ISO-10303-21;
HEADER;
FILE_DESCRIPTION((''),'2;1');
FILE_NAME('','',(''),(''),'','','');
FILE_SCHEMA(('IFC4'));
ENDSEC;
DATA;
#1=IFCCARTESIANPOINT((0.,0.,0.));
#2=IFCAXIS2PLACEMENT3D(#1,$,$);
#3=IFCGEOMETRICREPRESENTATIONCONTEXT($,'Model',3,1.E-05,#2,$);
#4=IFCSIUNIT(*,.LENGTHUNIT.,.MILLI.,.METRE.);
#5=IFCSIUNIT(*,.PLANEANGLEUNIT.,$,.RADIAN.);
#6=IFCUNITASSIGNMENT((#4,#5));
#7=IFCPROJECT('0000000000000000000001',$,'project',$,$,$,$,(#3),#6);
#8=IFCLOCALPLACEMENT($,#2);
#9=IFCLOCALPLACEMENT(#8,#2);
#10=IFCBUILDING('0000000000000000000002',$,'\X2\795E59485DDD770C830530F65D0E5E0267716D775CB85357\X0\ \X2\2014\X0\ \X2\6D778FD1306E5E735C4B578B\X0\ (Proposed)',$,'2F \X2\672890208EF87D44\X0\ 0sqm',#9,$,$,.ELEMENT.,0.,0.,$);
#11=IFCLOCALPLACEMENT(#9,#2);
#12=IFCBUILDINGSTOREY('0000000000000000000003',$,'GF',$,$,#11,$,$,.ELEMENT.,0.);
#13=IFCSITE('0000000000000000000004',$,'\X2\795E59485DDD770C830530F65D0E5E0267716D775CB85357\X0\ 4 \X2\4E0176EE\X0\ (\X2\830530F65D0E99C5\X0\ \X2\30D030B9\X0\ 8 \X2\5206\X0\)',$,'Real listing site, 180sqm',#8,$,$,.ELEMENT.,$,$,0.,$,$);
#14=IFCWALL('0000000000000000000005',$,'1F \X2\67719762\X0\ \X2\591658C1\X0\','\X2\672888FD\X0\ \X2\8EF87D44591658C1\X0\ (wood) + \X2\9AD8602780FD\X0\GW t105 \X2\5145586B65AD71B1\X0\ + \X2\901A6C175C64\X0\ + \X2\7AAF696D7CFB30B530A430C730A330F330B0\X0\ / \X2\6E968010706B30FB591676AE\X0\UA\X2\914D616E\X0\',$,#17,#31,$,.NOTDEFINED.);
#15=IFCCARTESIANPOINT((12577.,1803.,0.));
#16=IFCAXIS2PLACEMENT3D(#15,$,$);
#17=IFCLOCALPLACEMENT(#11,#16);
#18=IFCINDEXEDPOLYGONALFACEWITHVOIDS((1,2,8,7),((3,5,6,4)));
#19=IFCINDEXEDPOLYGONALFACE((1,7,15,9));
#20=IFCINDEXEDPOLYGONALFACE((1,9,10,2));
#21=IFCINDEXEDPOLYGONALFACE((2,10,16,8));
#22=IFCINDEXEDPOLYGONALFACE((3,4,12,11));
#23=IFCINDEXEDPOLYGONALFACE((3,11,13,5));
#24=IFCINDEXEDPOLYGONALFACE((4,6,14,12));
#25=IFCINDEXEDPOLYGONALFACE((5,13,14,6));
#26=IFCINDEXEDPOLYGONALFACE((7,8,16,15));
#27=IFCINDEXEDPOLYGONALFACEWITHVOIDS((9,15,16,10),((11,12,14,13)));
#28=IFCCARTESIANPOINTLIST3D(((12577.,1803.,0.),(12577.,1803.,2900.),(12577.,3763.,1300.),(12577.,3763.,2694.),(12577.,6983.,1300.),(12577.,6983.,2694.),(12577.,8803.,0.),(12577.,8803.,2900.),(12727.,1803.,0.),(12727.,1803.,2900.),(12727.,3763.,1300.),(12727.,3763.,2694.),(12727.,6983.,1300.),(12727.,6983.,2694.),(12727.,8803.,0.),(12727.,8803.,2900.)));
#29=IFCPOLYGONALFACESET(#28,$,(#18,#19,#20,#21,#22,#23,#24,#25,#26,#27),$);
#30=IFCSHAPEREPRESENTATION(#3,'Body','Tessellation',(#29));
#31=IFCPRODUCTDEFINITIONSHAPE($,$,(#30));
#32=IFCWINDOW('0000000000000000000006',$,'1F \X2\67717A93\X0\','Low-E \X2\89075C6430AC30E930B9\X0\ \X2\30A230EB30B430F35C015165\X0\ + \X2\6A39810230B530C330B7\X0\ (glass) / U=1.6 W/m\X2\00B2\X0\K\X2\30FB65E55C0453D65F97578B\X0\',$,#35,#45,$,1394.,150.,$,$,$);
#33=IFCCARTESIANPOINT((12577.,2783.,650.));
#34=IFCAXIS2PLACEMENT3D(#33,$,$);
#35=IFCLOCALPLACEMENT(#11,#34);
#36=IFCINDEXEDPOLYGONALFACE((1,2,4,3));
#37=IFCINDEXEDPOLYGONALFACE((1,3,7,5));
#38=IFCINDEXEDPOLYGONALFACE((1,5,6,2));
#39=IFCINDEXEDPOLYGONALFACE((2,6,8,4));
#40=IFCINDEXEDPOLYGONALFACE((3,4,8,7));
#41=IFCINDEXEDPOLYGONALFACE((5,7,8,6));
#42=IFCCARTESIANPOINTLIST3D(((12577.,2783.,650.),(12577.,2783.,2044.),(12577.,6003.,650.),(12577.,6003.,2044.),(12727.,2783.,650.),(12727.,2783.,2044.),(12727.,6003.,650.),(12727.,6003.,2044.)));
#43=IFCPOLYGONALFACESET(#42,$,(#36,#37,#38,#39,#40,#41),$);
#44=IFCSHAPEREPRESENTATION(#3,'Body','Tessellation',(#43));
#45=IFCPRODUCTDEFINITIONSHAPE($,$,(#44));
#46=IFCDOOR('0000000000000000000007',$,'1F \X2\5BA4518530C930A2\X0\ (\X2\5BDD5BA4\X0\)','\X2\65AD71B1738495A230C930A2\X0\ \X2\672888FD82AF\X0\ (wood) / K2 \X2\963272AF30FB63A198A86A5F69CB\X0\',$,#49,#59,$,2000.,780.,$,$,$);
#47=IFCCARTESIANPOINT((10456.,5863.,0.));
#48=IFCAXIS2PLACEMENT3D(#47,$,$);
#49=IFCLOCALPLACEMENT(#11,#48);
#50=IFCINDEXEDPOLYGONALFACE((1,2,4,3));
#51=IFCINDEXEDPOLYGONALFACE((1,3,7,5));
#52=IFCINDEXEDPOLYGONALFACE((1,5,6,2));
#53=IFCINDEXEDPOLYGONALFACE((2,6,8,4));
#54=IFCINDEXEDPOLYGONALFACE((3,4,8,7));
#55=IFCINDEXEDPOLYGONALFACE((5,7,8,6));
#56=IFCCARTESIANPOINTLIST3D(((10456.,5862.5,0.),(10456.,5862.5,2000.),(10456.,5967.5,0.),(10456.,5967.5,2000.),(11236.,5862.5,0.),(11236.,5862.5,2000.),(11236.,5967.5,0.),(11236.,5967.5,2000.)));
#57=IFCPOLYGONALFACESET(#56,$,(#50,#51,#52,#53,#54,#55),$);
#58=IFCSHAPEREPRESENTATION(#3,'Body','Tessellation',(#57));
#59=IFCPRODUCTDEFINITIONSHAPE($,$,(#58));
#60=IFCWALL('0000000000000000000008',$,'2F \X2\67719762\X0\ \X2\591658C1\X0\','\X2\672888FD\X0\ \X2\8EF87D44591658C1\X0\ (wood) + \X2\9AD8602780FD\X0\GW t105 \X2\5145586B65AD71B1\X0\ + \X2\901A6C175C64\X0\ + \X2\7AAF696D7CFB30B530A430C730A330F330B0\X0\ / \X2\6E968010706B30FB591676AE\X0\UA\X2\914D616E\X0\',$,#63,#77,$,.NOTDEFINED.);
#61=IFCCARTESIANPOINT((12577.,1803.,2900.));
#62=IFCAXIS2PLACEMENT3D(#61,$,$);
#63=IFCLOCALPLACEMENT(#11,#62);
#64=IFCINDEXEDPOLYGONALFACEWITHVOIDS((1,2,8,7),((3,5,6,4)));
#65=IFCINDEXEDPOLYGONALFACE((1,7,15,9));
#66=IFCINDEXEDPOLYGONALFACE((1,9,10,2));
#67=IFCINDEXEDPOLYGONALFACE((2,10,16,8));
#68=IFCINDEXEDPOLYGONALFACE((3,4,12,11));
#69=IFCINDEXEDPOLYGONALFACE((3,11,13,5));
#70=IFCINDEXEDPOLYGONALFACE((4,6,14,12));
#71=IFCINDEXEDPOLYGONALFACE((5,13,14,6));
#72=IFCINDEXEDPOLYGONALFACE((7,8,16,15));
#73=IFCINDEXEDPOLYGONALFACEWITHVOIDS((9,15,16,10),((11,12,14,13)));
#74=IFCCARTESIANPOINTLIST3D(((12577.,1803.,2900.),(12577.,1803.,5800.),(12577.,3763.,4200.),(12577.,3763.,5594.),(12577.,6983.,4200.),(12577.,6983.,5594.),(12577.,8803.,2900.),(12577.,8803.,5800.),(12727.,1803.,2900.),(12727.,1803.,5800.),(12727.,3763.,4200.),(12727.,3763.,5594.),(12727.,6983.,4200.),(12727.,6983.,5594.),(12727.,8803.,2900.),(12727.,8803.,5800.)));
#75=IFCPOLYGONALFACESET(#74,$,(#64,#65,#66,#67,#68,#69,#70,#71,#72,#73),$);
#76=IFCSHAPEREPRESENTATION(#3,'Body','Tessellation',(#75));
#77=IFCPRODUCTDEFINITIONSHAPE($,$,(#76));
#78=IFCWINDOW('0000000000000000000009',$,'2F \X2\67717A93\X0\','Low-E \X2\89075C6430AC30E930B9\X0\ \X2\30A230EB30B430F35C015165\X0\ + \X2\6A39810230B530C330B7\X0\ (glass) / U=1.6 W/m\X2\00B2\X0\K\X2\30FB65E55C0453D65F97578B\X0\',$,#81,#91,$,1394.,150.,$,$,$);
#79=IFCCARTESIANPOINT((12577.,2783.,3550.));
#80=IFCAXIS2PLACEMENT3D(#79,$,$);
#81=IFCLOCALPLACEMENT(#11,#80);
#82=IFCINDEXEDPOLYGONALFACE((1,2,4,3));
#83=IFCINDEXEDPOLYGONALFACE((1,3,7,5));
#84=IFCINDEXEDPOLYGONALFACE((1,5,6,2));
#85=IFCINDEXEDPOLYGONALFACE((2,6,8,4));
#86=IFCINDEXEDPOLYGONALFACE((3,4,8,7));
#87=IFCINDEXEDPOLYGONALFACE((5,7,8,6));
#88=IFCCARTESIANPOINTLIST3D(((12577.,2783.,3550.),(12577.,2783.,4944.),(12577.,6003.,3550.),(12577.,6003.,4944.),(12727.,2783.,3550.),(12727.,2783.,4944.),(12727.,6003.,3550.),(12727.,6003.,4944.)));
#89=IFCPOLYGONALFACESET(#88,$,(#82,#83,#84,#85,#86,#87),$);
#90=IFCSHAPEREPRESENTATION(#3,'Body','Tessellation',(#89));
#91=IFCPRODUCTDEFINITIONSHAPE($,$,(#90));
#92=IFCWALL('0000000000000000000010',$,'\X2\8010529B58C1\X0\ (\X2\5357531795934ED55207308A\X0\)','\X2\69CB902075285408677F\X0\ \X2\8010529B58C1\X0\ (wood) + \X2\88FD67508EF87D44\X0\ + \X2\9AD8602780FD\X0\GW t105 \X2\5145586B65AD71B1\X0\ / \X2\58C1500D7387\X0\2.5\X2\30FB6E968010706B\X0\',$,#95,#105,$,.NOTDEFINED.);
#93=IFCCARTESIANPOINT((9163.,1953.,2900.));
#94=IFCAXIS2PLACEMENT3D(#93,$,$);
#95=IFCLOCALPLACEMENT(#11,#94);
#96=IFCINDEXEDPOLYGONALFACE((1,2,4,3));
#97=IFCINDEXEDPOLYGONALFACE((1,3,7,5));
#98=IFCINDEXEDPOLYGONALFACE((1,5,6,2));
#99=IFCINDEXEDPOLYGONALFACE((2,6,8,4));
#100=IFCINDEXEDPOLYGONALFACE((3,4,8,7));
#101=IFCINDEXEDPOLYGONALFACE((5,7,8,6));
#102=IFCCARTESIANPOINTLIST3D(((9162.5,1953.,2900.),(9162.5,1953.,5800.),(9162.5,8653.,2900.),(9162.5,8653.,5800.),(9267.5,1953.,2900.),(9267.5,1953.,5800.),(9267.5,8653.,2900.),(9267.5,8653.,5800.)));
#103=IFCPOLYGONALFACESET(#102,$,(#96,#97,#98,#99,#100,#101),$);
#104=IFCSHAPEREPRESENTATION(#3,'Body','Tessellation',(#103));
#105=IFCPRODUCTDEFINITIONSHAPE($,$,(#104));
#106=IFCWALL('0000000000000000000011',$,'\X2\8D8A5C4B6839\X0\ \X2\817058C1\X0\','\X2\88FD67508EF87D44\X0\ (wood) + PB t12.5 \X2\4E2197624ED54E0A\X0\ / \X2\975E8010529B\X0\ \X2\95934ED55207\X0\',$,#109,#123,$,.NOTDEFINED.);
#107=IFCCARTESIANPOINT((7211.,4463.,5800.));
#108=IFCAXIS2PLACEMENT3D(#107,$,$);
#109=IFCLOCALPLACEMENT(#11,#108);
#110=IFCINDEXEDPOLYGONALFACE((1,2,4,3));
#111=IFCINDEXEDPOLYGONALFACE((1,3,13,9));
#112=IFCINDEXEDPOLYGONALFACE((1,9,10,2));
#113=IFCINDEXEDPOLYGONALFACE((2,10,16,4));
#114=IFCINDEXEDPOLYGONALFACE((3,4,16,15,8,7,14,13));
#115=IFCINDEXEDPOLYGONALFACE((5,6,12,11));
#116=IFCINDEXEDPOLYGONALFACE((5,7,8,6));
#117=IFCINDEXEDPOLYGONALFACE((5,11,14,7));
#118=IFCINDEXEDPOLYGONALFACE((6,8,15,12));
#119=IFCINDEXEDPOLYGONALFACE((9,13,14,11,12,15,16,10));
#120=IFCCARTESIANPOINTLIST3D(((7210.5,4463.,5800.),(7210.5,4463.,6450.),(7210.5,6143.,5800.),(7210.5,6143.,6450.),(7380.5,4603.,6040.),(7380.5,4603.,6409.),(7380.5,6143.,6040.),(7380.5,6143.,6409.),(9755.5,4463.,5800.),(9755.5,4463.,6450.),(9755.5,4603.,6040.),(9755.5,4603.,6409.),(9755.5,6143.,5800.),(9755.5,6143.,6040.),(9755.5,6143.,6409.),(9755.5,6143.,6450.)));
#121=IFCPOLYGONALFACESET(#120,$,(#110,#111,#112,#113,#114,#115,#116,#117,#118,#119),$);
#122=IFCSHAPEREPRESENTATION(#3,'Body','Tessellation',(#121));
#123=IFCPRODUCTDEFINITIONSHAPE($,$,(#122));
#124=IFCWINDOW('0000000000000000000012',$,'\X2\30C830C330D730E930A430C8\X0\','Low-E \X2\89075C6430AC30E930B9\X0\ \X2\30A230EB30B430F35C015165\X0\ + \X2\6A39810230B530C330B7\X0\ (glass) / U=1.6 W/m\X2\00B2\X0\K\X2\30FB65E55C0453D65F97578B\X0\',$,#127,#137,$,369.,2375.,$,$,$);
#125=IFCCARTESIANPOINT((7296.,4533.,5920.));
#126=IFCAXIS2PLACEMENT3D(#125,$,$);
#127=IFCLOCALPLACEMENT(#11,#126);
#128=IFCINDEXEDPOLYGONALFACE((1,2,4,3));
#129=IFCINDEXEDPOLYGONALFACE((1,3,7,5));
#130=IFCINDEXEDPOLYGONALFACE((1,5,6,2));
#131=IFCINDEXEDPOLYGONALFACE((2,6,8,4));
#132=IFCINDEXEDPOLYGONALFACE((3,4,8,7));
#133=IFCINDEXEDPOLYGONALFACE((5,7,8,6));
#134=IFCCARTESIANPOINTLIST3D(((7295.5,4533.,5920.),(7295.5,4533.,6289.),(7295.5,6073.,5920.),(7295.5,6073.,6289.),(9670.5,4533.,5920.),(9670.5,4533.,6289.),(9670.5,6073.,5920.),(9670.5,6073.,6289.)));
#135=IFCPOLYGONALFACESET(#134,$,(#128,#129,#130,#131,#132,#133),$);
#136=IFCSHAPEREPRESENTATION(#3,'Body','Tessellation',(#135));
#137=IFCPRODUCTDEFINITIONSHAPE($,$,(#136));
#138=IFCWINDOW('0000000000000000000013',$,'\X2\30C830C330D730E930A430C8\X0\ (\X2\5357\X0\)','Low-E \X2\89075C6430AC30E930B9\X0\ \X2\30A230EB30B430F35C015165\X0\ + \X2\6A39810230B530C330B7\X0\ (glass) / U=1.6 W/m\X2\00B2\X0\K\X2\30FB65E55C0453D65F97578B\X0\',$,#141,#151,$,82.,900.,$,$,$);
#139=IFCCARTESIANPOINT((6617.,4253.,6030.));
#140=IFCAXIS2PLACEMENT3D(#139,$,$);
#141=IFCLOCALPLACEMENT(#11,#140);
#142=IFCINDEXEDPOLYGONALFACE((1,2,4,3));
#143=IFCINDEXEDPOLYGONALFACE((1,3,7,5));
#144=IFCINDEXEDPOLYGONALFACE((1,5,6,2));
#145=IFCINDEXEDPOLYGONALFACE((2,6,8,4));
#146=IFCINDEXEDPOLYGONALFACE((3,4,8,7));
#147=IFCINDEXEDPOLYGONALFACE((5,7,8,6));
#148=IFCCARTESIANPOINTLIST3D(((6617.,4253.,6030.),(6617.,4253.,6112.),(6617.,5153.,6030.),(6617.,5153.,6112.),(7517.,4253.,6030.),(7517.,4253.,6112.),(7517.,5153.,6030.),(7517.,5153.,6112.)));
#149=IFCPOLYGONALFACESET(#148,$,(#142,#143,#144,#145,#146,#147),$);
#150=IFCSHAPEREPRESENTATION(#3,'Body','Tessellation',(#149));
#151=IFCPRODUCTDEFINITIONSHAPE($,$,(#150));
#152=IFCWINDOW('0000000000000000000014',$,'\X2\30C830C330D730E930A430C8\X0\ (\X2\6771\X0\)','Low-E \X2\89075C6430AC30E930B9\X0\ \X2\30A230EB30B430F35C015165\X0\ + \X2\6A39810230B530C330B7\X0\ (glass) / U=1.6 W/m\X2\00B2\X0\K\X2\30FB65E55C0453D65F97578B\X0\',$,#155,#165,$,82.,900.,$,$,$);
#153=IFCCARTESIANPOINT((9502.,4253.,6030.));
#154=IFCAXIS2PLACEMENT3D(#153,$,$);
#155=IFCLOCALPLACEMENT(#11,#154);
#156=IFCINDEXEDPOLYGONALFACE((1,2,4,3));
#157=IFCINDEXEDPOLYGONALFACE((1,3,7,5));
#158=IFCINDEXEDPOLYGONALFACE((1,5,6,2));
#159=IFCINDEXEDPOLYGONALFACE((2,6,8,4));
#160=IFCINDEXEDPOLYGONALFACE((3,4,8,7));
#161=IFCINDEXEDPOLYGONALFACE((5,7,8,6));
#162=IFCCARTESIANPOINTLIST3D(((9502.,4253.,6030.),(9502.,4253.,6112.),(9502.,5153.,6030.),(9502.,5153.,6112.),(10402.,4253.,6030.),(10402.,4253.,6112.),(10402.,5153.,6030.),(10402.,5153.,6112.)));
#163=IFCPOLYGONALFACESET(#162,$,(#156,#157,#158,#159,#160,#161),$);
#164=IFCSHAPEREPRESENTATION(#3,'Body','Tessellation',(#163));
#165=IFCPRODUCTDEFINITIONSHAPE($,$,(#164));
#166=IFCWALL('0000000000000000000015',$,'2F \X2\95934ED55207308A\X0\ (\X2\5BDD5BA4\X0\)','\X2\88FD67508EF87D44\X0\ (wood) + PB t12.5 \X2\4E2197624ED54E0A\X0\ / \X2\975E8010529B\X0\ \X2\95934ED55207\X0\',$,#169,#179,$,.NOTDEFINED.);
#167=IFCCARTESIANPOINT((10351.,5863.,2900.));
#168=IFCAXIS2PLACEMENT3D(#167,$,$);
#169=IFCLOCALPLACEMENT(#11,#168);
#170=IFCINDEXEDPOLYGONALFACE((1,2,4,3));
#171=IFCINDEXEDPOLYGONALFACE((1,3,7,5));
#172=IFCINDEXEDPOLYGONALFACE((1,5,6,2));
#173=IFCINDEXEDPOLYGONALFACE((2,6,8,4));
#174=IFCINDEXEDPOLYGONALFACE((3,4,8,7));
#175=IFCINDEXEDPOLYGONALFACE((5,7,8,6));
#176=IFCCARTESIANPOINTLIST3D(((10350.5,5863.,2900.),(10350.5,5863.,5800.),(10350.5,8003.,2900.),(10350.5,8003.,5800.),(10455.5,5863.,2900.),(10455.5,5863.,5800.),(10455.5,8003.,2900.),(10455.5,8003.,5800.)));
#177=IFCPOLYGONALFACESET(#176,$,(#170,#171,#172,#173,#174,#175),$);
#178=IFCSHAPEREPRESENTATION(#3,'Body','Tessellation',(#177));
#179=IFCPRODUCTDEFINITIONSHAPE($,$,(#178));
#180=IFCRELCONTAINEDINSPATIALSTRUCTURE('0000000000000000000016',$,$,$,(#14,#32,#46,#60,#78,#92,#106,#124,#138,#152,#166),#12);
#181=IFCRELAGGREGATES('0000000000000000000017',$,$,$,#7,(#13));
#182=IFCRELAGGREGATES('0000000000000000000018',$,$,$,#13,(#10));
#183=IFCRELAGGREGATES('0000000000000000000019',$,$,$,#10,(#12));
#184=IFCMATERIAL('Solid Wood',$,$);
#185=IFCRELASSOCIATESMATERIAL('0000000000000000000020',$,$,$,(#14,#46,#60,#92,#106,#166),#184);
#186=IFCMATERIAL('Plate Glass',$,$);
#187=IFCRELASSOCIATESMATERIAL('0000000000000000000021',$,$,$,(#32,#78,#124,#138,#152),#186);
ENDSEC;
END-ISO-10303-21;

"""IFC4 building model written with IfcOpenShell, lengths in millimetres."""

from ifc_helpers import new_model, si_unit, frame, frame_2d, origin, place, context, project, spatial, rectangle, extrude, material, element, fill, save


model = new_model("IFC4")

# Units and contexts
model_context = context("Model", 3, precision=1e-05, world=origin())
ifc_project = project(units=[si_unit("LENGTHUNIT", "METRE", prefix="MILLI"), si_unit("PLANEANGLEUNIT", "RADIAN")], contexts=[model_context])

# Site, building, storey
site_placement = place(None, origin())
site = spatial("IfcSite", under=ifc_project, at=site_placement, Name="神奈川県茅ヶ崎市東海岸南 4 丁目 (茅ヶ崎駅 バス 8 分)", ObjectType="Real listing site, 180sqm", CompositionType="ELEMENT", RefElevation=0.0)
building_placement = place(site_placement, origin())
building = spatial("IfcBuilding", under=site, at=building_placement, Name="神奈川県茅ヶ崎市東海岸南 — 海近の平屋型 (Proposed)", ObjectType="2F 木造軸組 0sqm", CompositionType="ELEMENT", ElevationOfRefHeight=0.0, ElevationOfTerrain=0.0)
storey_placement = place(building_placement, origin())
storey = spatial("IfcBuildingStorey", under=building, at=storey_placement, Name="GF", CompositionType="ELEMENT", Elevation=0.0)

# Wall, opening, window
ifc_material_1 = material(Name="Solid Wood")
wall_1_placement = place(storey_placement, frame((12577.0, 1803.0, 0.0)))
wall_1 = element("IfcWall", 1, at=wall_1_placement, inside=storey, material=ifc_material_1, Name="1F 東面 外壁", Description="木製 軸組外壁 (wood) + 高性能GW t105 充填断熱 + 通気層 + 窯業系サイディング / 準耐火・外皮UA配慮", PredefinedType="NOTDEFINED", context=model_context, shape_type="SweptSolid", body=[
    extrude(rectangle(XDim=150.0, YDim=7000.0, at=frame_2d((75.0, 3500.0))), frame((12577.0, 1803.0, 0.0)), (0.0, 0.0, 1.0), 2900.0),
])
opening_1_placement = place(storey_placement, frame((12577.0, 2783.0, 650.0)))
opening_1 = element("IfcOpeningElement", 2, at=opening_1_placement, cuts=wall_1, PredefinedType="NOTDEFINED", context=model_context, shape_type="SweptSolid", body=[
    extrude(rectangle(XDim=150.0, YDim=3220.0, at=frame_2d((75.0, 1610.0))), frame((12577.0, 2783.0, 650.0)), (0.0, 0.0, 1.0), 1394.0),
])
ifc_material_2 = material(Name="Plate Glass")
window_1_placement = place(storey_placement, frame((12577.0, 2783.0, 650.0)))
window_1 = element("IfcWindow", 3, at=window_1_placement, inside=storey, material=ifc_material_2, Name="1F 東窓", Description="Low-E 複層ガラス アルゴン封入 + 樹脂サッシ (glass) / U=1.6 W/m²K・日射取得型", OverallHeight=1394.0, OverallWidth=150.0, context=model_context, shape_type="SweptSolid", body=[
    extrude(rectangle(XDim=150.0, YDim=3220.0, at=frame_2d((75.0, 1610.0))), frame((12577.0, 2783.0, 650.0)), (0.0, 0.0, 1.0), 1394.0),
])
fill(opening_1, window_1)

# Door
door_1_placement = place(storey_placement, frame((10456.0, 5863.0, 0.0)))
element("IfcDoor", 4, at=door_1_placement, inside=storey, material=ifc_material_1, Name="1F 室内ドア (寝室)", Description="断熱玄関ドア 木製芯 (wood) / K2 防犯・採風機構", OverallHeight=2000.0, OverallWidth=780.0, context=model_context, shape_type="SweptSolid", body=[
    extrude(rectangle(XDim=780.0, YDim=105.0, at=frame_2d((390.0, 52.0))), frame((10456.0, 5863.0, 0.0)), (0.0, 0.0, 1.0), 2000.0),
])

# Wall, opening, window
wall_2_placement = place(storey_placement, frame((12577.0, 1803.0, 2900.0)))
wall_2 = element("IfcWall", 5, at=wall_2_placement, inside=storey, material=ifc_material_1, Name="2F 東面 外壁", Description="木製 軸組外壁 (wood) + 高性能GW t105 充填断熱 + 通気層 + 窯業系サイディング / 準耐火・外皮UA配慮", PredefinedType="NOTDEFINED", context=model_context, shape_type="SweptSolid", body=[
    extrude(rectangle(XDim=150.0, YDim=7000.0, at=frame_2d((75.0, 3500.0))), frame((12577.0, 1803.0, 2900.0)), (0.0, 0.0, 1.0), 2900.0),
])
opening_2_placement = place(storey_placement, frame((12577.0, 2783.0, 3550.0)))
opening_2 = element("IfcOpeningElement", 6, at=opening_2_placement, cuts=wall_2, PredefinedType="NOTDEFINED", context=model_context, shape_type="SweptSolid", body=[
    extrude(rectangle(XDim=150.0, YDim=3220.0, at=frame_2d((75.0, 1610.0))), frame((12577.0, 2783.0, 3550.0)), (0.0, 0.0, 1.0), 1394.0),
])
window_2_placement = place(storey_placement, frame((12577.0, 2783.0, 3550.0)))
window_2 = element("IfcWindow", 7, at=window_2_placement, inside=storey, material=ifc_material_2, Name="2F 東窓", Description="Low-E 複層ガラス アルゴン封入 + 樹脂サッシ (glass) / U=1.6 W/m²K・日射取得型", OverallHeight=1394.0, OverallWidth=150.0, context=model_context, shape_type="SweptSolid", body=[
    extrude(rectangle(XDim=150.0, YDim=3220.0, at=frame_2d((75.0, 1610.0))), frame((12577.0, 2783.0, 3550.0)), (0.0, 0.0, 1.0), 1394.0),
])
fill(opening_2, window_2)

# Wall
wall_3_placement = place(storey_placement, frame((9163.0, 1953.0, 2900.0)))
element("IfcWall", 8, at=wall_3_placement, inside=storey, material=ifc_material_1, Name="耐力壁 (南北間仕切り)", Description="構造用合板 耐力壁 (wood) + 製材軸組 + 高性能GW t105 充填断熱 / 壁倍率2.5・準耐火", PredefinedType="NOTDEFINED", context=model_context, shape_type="SweptSolid", body=[
    extrude(rectangle(XDim=105.0, YDim=6700.0, at=frame_2d((52.0, 3350.0))), frame((9163.0, 1953.0, 2900.0)), (0.0, 0.0, 1.0), 2900.0),
])

# Wall, openings, windows
wall_4_placement = place(storey_placement, frame((7211.0, 4463.0, 5800.0)))
wall_4 = element("IfcWall", 9, at=wall_4_placement, inside=storey, material=ifc_material_1, Name="越屋根 腰壁", Description="製材軸組 (wood) + PB t12.5 両面仕上 / 非耐力 間仕切", PredefinedType="NOTDEFINED", context=model_context, shape_type="SweptSolid", body=[
    extrude(rectangle(XDim=2545.0, YDim=1680.0, at=frame_2d((1272.0, 840.0))), frame((7211.0, 4463.0, 5800.0)), (0.0, 0.0, 1.0), 650.0),
])
opening_3_placement = place(storey_placement, frame((7296.0, 4533.0, 5920.0)))
opening_3 = element("IfcOpeningElement", 10, at=opening_3_placement, cuts=wall_4, PredefinedType="NOTDEFINED", context=model_context, shape_type="SweptSolid", body=[
    extrude(rectangle(XDim=2375.0, YDim=1540.0, at=frame_2d((1187.0, 770.0))), frame((7296.0, 4533.0, 5920.0)), (0.0, 0.0, 1.0), 369.0),
])
opening_4_placement = place(storey_placement, frame((6617.0, 4253.0, 6030.0)))
opening_4 = element("IfcOpeningElement", 11, at=opening_4_placement, cuts=wall_4, PredefinedType="NOTDEFINED", context=model_context, shape_type="SweptSolid", body=[
    extrude(rectangle(XDim=900.0, YDim=900.0, at=frame_2d((450.0, 450.0))), frame((6617.0, 4253.0, 6030.0)), (0.0, 0.0, 1.0), 82.0),
])
opening_5_placement = place(storey_placement, frame((9502.0, 4253.0, 6030.0)))
opening_5 = element("IfcOpeningElement", 12, at=opening_5_placement, cuts=wall_4, PredefinedType="NOTDEFINED", context=model_context, shape_type="SweptSolid", body=[
    extrude(rectangle(XDim=900.0, YDim=900.0, at=frame_2d((450.0, 450.0))), frame((9502.0, 4253.0, 6030.0)), (0.0, 0.0, 1.0), 82.0),
])
window_3_placement = place(storey_placement, frame((7296.0, 4533.0, 5920.0)))
window_3 = element("IfcWindow", 13, at=window_3_placement, inside=storey, material=ifc_material_2, Name="トップライト", Description="Low-E 複層ガラス アルゴン封入 + 樹脂サッシ (glass) / U=1.6 W/m²K・日射取得型", OverallHeight=369.0, OverallWidth=2375.0, context=model_context, shape_type="SweptSolid", body=[
    extrude(rectangle(XDim=2375.0, YDim=1540.0, at=frame_2d((1187.0, 770.0))), frame((7296.0, 4533.0, 5920.0)), (0.0, 0.0, 1.0), 369.0),
])
fill(opening_3, window_3)
window_4_placement = place(storey_placement, frame((6617.0, 4253.0, 6030.0)))
window_4 = element("IfcWindow", 14, at=window_4_placement, inside=storey, material=ifc_material_2, Name="トップライト (南)", Description="Low-E 複層ガラス アルゴン封入 + 樹脂サッシ (glass) / U=1.6 W/m²K・日射取得型", OverallHeight=82.0, OverallWidth=900.0, context=model_context, shape_type="SweptSolid", body=[
    extrude(rectangle(XDim=900.0, YDim=900.0, at=frame_2d((450.0, 450.0))), frame((6617.0, 4253.0, 6030.0)), (0.0, 0.0, 1.0), 82.0),
])
fill(opening_4, window_4)
window_5_placement = place(storey_placement, frame((9502.0, 4253.0, 6030.0)))
window_5 = element("IfcWindow", 15, at=window_5_placement, inside=storey, material=ifc_material_2, Name="トップライト (東)", Description="Low-E 複層ガラス アルゴン封入 + 樹脂サッシ (glass) / U=1.6 W/m²K・日射取得型", OverallHeight=82.0, OverallWidth=900.0, context=model_context, shape_type="SweptSolid", body=[
    extrude(rectangle(XDim=900.0, YDim=900.0, at=frame_2d((450.0, 450.0))), frame((9502.0, 4253.0, 6030.0)), (0.0, 0.0, 1.0), 82.0),
])
fill(opening_5, window_5)

# Wall
wall_5_placement = place(storey_placement, frame((10351.0, 5863.0, 2900.0)))
element("IfcWall", 16, at=wall_5_placement, inside=storey, material=ifc_material_1, Name="2F 間仕切り (寝室)", Description="製材軸組 (wood) + PB t12.5 両面仕上 / 非耐力 間仕切", PredefinedType="NOTDEFINED", context=model_context, shape_type="SweptSolid", body=[
    extrude(rectangle(XDim=105.0, YDim=2140.0, at=frame_2d((52.0, 1070.0))), frame((10351.0, 5863.0, 2900.0)), (0.0, 0.0, 1.0), 2900.0),
])

save(model, "model.ifc")
